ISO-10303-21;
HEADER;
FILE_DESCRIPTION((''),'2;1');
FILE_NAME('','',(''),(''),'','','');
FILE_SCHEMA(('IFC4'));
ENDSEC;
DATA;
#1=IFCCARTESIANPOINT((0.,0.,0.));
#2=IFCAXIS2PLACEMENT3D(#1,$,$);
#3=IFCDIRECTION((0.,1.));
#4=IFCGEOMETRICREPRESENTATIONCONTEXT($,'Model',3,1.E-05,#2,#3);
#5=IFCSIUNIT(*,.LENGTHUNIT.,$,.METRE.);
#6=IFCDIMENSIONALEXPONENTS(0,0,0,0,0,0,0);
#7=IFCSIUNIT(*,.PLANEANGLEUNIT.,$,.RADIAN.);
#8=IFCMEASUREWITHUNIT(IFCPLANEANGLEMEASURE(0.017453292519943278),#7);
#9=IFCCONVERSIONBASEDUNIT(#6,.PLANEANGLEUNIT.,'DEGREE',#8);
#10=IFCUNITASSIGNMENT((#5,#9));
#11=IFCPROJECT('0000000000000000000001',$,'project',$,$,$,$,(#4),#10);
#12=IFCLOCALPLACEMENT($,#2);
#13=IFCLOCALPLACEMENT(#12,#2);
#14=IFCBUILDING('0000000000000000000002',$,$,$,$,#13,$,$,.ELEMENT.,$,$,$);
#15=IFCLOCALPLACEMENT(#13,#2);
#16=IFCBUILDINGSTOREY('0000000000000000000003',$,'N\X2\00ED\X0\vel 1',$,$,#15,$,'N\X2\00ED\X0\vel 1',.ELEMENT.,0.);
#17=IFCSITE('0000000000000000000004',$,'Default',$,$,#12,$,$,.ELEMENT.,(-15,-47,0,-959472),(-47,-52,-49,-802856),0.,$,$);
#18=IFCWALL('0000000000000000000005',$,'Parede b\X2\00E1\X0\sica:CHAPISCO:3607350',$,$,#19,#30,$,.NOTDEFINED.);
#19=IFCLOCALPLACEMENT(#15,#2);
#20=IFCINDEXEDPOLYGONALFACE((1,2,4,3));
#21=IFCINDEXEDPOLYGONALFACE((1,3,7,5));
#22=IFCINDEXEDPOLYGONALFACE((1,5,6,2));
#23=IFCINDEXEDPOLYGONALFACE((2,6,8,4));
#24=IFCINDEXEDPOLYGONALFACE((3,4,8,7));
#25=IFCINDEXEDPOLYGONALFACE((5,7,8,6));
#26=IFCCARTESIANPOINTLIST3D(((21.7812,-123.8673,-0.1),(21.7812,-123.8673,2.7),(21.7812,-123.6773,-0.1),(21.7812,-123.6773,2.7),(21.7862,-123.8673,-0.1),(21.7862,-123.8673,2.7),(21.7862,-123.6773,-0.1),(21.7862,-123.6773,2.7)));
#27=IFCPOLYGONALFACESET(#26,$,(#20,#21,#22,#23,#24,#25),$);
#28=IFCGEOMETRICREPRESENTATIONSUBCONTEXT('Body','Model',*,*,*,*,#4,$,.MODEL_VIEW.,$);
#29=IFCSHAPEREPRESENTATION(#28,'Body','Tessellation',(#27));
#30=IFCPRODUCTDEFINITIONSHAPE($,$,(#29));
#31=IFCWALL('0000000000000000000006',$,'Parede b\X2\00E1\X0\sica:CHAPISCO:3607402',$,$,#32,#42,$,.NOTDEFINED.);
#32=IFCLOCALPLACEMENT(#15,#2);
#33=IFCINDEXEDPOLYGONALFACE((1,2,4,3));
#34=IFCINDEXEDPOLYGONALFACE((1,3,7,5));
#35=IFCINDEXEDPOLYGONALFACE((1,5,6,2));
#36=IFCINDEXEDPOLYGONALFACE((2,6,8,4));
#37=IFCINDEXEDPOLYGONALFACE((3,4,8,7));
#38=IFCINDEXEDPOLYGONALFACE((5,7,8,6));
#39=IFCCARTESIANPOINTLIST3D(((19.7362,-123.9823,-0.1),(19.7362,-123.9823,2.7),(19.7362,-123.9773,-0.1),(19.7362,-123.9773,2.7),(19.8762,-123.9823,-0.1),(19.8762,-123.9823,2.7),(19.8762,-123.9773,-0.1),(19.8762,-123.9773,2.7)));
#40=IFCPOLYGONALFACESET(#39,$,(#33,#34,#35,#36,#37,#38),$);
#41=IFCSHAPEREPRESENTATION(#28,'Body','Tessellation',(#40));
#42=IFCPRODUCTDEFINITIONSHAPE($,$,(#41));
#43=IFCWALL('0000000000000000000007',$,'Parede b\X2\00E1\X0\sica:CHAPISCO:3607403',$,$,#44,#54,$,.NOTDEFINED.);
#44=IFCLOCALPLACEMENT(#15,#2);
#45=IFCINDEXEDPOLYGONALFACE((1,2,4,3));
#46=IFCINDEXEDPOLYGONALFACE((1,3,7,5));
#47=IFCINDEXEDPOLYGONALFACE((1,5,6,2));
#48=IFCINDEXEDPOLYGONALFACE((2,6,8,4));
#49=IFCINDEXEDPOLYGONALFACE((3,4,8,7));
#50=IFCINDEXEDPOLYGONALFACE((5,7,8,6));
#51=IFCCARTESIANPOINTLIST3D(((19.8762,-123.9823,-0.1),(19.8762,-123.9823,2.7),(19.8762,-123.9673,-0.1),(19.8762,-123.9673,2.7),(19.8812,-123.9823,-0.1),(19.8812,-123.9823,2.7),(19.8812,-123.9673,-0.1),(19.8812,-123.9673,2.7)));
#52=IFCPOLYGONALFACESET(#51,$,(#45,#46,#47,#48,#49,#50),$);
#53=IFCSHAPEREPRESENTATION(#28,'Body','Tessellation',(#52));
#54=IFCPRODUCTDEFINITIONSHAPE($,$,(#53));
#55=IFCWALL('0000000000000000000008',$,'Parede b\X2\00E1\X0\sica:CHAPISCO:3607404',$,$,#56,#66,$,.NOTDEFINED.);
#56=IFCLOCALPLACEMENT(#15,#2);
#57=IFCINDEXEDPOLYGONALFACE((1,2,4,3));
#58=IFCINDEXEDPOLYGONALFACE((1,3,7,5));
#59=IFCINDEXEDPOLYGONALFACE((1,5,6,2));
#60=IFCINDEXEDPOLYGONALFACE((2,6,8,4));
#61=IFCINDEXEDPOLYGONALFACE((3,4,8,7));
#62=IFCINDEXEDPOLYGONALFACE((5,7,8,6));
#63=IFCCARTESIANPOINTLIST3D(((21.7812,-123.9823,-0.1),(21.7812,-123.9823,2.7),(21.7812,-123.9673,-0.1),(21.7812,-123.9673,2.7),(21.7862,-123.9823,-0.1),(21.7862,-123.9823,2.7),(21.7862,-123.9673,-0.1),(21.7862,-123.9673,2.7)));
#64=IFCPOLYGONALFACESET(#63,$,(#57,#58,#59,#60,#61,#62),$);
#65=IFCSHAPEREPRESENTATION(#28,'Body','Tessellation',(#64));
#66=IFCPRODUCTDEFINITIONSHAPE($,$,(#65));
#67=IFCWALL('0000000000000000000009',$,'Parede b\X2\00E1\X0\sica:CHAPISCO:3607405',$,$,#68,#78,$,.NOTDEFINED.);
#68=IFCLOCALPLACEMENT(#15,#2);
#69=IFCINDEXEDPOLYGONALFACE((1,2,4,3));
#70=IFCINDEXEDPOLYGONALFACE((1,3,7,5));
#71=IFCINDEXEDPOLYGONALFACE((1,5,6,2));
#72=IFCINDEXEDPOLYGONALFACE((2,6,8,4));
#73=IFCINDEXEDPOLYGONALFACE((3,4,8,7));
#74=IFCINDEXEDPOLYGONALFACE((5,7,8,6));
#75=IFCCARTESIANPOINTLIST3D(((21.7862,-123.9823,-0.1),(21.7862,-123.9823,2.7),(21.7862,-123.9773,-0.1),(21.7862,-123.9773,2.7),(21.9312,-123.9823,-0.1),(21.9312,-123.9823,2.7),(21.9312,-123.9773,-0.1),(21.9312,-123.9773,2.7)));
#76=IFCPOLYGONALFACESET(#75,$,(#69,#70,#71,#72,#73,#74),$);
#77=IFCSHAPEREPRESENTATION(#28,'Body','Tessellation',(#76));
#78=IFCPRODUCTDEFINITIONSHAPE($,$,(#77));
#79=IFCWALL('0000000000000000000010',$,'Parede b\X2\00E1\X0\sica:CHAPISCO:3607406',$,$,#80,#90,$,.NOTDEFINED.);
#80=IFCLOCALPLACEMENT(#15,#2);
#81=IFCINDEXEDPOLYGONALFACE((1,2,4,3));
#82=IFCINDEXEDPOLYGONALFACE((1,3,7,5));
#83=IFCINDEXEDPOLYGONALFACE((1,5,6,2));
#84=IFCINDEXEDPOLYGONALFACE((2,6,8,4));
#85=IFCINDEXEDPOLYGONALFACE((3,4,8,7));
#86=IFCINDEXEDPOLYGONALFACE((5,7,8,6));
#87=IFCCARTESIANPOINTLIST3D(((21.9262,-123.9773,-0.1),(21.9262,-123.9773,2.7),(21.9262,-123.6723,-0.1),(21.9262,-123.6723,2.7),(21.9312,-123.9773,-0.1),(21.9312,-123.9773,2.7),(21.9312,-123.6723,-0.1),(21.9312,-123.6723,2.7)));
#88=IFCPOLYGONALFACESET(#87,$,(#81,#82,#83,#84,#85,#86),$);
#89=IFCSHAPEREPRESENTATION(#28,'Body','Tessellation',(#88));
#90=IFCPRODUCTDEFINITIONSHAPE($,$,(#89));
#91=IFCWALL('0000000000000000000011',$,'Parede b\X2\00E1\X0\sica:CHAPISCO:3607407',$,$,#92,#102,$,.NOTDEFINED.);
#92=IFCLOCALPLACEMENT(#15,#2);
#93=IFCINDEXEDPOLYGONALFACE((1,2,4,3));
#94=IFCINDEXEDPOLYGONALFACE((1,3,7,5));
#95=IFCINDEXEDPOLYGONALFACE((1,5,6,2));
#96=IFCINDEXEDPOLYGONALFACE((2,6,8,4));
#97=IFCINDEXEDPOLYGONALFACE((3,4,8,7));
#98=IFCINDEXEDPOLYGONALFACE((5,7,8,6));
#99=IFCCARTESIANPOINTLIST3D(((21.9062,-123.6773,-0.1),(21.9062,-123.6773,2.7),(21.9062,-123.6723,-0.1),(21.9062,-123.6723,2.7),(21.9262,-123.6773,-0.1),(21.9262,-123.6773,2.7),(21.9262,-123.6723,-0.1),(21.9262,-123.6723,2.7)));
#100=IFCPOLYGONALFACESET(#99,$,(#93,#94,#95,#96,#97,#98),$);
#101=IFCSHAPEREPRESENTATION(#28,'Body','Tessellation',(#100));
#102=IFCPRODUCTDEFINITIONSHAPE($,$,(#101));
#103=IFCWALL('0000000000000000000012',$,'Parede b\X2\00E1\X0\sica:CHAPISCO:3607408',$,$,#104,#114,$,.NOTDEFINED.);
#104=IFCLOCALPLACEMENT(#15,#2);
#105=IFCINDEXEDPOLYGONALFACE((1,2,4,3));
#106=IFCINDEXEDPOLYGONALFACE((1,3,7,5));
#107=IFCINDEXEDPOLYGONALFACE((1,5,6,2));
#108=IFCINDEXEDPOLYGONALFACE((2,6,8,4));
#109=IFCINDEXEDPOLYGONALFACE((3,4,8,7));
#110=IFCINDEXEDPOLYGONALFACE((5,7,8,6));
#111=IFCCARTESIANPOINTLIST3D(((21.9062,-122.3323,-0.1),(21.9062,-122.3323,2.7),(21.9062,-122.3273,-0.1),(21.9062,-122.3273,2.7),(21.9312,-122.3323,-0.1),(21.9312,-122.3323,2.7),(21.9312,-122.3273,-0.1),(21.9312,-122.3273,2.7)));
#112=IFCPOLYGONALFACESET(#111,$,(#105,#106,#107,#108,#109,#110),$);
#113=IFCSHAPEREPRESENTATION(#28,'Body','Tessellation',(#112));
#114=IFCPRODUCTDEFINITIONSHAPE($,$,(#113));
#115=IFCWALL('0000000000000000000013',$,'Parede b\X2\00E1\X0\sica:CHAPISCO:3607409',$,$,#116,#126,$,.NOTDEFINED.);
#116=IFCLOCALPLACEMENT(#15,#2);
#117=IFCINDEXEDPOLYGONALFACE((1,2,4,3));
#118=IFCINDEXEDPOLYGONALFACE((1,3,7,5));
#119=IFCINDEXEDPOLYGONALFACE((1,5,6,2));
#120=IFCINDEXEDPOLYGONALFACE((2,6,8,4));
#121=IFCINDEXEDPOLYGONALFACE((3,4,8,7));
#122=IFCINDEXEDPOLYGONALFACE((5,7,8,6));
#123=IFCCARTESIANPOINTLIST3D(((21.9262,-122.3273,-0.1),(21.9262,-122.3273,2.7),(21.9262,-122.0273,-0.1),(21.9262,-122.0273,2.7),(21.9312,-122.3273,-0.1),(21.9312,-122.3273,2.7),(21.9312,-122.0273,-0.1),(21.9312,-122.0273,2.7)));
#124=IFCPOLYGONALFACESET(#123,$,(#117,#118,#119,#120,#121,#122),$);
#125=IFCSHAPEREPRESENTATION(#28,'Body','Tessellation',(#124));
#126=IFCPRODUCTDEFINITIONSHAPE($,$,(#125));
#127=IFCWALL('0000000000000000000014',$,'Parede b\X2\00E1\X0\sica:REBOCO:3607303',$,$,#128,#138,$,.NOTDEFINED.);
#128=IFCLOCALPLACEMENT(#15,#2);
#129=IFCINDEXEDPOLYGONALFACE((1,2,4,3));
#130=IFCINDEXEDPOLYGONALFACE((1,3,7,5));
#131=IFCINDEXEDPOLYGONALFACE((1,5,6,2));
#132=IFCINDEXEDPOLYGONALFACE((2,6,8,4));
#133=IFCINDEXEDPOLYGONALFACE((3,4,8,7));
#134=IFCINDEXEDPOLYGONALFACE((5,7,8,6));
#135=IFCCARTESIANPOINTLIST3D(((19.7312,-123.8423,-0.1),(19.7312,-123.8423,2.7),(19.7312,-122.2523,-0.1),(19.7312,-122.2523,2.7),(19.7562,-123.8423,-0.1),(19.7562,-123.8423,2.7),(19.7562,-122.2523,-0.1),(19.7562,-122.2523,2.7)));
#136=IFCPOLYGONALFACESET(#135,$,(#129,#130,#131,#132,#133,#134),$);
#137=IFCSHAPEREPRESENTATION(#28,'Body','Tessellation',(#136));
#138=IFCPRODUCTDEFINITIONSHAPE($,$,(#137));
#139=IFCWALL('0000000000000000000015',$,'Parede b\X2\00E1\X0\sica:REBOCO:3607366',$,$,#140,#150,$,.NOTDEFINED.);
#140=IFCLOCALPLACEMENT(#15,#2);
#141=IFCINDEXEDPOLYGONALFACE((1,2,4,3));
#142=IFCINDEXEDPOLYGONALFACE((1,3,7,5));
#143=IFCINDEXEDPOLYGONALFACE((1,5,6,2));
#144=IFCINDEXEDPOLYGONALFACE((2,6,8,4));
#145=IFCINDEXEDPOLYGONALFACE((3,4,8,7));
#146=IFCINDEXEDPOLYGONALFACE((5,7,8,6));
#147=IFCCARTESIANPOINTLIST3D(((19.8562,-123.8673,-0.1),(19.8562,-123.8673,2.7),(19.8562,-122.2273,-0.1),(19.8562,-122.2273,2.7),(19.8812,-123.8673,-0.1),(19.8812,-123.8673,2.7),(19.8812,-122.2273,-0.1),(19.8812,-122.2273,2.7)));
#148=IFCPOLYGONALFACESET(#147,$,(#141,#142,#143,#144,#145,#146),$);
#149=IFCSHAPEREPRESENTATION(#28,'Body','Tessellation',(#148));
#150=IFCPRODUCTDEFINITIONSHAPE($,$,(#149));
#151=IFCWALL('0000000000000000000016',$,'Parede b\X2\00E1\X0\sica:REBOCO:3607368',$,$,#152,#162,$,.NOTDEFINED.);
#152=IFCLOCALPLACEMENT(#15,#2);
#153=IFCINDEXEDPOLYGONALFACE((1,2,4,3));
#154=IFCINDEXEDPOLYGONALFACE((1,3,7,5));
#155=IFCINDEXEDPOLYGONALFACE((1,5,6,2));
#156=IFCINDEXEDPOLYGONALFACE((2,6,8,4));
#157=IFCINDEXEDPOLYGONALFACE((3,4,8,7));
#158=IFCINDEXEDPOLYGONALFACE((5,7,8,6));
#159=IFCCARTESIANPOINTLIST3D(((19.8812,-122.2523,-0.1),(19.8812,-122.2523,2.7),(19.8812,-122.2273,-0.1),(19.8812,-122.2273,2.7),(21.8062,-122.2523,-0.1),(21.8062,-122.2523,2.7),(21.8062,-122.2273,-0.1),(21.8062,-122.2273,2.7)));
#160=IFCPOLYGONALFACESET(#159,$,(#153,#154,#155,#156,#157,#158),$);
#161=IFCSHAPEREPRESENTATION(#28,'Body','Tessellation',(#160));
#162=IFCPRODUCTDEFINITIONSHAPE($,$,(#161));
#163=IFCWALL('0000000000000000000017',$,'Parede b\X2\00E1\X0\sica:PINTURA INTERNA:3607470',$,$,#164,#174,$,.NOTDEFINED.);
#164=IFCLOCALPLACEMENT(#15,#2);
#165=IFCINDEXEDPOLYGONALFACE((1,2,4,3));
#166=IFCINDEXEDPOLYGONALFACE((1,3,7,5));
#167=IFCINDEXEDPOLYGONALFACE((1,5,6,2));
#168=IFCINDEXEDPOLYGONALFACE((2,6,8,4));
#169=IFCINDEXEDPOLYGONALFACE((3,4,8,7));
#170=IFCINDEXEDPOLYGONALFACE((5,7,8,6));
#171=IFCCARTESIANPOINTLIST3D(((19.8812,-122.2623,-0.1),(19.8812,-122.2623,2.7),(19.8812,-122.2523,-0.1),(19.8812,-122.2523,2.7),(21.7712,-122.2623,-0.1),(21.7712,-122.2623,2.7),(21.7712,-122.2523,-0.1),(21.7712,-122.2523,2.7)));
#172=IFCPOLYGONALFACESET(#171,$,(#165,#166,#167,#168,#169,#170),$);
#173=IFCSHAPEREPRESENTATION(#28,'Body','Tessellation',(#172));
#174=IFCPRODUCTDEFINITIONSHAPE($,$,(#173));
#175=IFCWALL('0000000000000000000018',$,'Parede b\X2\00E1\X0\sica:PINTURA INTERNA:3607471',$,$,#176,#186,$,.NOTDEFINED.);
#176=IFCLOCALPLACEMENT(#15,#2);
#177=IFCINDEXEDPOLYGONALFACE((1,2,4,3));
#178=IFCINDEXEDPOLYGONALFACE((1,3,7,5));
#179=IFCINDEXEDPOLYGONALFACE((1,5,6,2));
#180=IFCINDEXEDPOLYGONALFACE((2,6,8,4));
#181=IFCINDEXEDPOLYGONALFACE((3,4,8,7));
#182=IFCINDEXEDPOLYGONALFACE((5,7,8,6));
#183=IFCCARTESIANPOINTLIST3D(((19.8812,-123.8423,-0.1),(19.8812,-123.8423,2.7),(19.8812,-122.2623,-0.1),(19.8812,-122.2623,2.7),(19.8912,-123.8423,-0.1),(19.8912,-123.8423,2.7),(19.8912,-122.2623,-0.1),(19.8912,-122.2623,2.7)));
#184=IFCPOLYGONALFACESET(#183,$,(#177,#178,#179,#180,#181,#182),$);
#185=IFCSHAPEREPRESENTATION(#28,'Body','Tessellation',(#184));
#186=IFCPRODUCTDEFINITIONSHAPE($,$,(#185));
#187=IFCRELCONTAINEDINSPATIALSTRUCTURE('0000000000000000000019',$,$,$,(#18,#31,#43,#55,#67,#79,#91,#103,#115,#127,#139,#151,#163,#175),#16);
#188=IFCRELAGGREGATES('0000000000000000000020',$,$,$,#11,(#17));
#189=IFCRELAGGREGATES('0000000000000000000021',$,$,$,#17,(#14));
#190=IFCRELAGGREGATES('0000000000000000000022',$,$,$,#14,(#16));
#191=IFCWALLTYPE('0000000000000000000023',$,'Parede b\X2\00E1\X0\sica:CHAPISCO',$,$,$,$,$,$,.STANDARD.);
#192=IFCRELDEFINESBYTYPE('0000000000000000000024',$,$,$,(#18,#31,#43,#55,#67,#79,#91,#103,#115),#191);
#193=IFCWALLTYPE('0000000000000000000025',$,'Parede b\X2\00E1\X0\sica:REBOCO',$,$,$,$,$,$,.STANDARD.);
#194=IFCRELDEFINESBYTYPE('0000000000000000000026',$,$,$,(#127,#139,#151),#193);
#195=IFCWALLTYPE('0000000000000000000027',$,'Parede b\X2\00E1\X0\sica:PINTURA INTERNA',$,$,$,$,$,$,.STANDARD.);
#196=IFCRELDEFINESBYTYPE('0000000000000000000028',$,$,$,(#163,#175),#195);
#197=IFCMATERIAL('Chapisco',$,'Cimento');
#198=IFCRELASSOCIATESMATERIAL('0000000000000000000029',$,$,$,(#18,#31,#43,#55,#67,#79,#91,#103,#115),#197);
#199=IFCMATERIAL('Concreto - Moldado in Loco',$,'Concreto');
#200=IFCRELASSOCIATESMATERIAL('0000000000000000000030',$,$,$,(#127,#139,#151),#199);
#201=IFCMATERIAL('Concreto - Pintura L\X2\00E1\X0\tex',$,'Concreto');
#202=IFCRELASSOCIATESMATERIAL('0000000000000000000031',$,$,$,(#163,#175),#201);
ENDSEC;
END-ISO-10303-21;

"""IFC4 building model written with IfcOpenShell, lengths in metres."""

from ifc_helpers import new_model, entity, si_unit, converted_unit, direction, frame, origin, place, context, subcontext, project, spatial, indexed_curve, outline, extrude, material, type_object, element, save


model = new_model("IFC4")

# Units and contexts
model_context = context("Model", 3, precision=1e-05, world=origin(), true_north=direction((0.0, 1.0)))
body_context = subcontext(model_context, "Body", "Model", "MODEL_VIEW")
ifc_project = project(units=[si_unit("LENGTHUNIT", "METRE"), converted_unit("PLANEANGLEUNIT", "DEGREE", entity("IfcPlaneAngleMeasure", 0.017453292519943278), si_unit("PLANEANGLEUNIT", "RADIAN"), dimensions=[0, 0, 0, 0, 0, 0, 0])], contexts=[model_context])

# Site, building, storey
site_placement = place(None, origin())
site = spatial("IfcSite", under=ifc_project, at=site_placement, Name="Default", CompositionType="ELEMENT", RefLatitude=(-15, -47, 0, -959472), RefLongitude=(-47, -52, -49, -802856), RefElevation=0.0)
building_placement = place(site_placement, origin())
building = spatial("IfcBuilding", under=site, at=building_placement, CompositionType="ELEMENT")
storey_placement = place(building_placement, origin())
storey = spatial("IfcBuildingStorey", under=building, at=storey_placement, Name="Nível 1", LongName="Nível 1", CompositionType="ELEMENT", Elevation=0.0)

# Walls
ifc_material_1 = material(Name="Chapisco", Category="Cimento")
wall_type_1 = type_object("IfcWallType", Name="Parede básica:CHAPISCO", PredefinedType="STANDARD")
wall_1_placement = place(storey_placement, frame((21.7837, -123.6773, -0.1), z_axis=(0.0, 0.0, 1.0), x_axis=(0.0, -1.0, 0.0)))
element("IfcWall", 1, at=wall_1_placement, inside=storey, type_object=wall_type_1, material=ifc_material_1, Name="Parede básica:CHAPISCO:3607350", PredefinedType="NOTDEFINED", context=body_context, shape_type="SweptSolid", body=[
    extrude(outline(indexed_curve([(0.19, 0.0025), (0.0, 0.0025), (0.0, -0.0025), (0.19, -0.0025), (0.19, 0.0025)], self_intersect=False)), origin(), (0.0, 0.0, 1.0), 2.8),
])
wall_2_placement = place(storey_placement, frame((19.7362, -123.9798, -0.1)))
element("IfcWall", 2, at=wall_2_placement, inside=storey, type_object=wall_type_1, material=ifc_material_1, Name="Parede básica:CHAPISCO:3607402", PredefinedType="NOTDEFINED", context=body_context, shape_type="SweptSolid", body=[
    extrude(outline(indexed_curve([(0.14, 0.0025), (0.0, 0.0025), (0.0, -0.0025), (0.14, -0.0025), (0.14, 0.0025)], self_intersect=False)), origin(), (0.0, 0.0, 1.0), 2.8),
])
for number, where, z_axis, x_axis, name in (
    (3, (19.8787, -123.9823, -0.1), (0.0, 0.0, 1.0), (0.0, 1.0, 0.0), "Parede básica:CHAPISCO:3607403"),
    (4, (21.7837, -123.9673, -0.1), (0.0, 0.0, 1.0), (0.0, -1.0, 0.0), "Parede básica:CHAPISCO:3607404"),
):
    element("IfcWall", number, at=place(storey_placement, frame(where, z_axis=z_axis, x_axis=x_axis)), inside=storey, type_object=wall_type_1, material=ifc_material_1, Name=name, PredefinedType="NOTDEFINED", context=body_context, shape_type="SweptSolid", body=[
        extrude(outline(indexed_curve([(0.015, 0.0025), (0.0, 0.0025), (0.0, -0.0025), (0.015, -0.0025), (0.015, 0.0025)], self_intersect=False)), origin(), (0.0, 0.0, 1.0), 2.8),
    ])
wall_3_placement = place(storey_placement, frame((21.7862, -123.9798, -0.1)))
element("IfcWall", 5, at=wall_3_placement, inside=storey, type_object=wall_type_1, material=ifc_material_1, Name="Parede básica:CHAPISCO:3607405", PredefinedType="NOTDEFINED", context=body_context, shape_type="SweptSolid", body=[
    extrude(outline(indexed_curve([(0.145, 0.0025), (0.0, 0.0025), (0.0, -0.0025), (0.145, -0.0025), (0.145, 0.0025)], self_intersect=False)), origin(), (0.0, 0.0, 1.0), 2.8),
])
wall_4_placement = place(storey_placement, frame((21.9287, -123.9773, -0.1), z_axis=(0.0, 0.0, 1.0), x_axis=(0.0, 1.0, 0.0)))
element("IfcWall", 6, at=wall_4_placement, inside=storey, type_object=wall_type_1, material=ifc_material_1, Name="Parede básica:CHAPISCO:3607406", PredefinedType="NOTDEFINED", context=body_context, shape_type="SweptSolid", body=[
    extrude(outline(indexed_curve([(0.305, 0.0025), (0.0, 0.0025), (0.0, -0.0025), (0.305, -0.0025), (0.305, 0.0025)], self_intersect=False)), origin(), (0.0, 0.0, 1.0), 2.8),
])
wall_5_placement = place(storey_placement, frame((21.9262, -123.6748, -0.1), z_axis=(0.0, 0.0, 1.0), x_axis=(-1.0, 0.0, 0.0)))
element("IfcWall", 7, at=wall_5_placement, inside=storey, type_object=wall_type_1, material=ifc_material_1, Name="Parede básica:CHAPISCO:3607407", PredefinedType="NOTDEFINED", context=body_context, shape_type="SweptSolid", body=[
    extrude(outline(indexed_curve([(0.02, 0.0025), (0.0, 0.0025), (0.0, -0.0025), (0.02, -0.0025), (0.02, 0.0025)], self_intersect=False)), origin(), (0.0, 0.0, 1.0), 2.8),
])
wall_6_placement = place(storey_placement, frame((21.9062, -122.3298, -0.1)))
element("IfcWall", 8, at=wall_6_placement, inside=storey, type_object=wall_type_1, material=ifc_material_1, Name="Parede básica:CHAPISCO:3607408", PredefinedType="NOTDEFINED", context=body_context, shape_type="SweptSolid", body=[
    extrude(outline(indexed_curve([(0.025, 0.0025), (0.0, 0.0025), (0.0, -0.0025), (0.025, -0.0025), (0.025, 0.0025)], self_intersect=False)), origin(), (0.0, 0.0, 1.0), 2.8),
])
wall_7_placement = place(storey_placement, frame((21.9287, -122.3273, -0.1), z_axis=(0.0, 0.0, 1.0), x_axis=(0.0, 1.0, 0.0)))
element("IfcWall", 9, at=wall_7_placement, inside=storey, type_object=wall_type_1, material=ifc_material_1, Name="Parede básica:CHAPISCO:3607409", PredefinedType="NOTDEFINED", context=body_context, shape_type="SweptSolid", body=[
    extrude(outline(indexed_curve([(0.3, 0.0025), (0.0, 0.0025), (0.0, -0.0025), (0.3, -0.0025), (0.3, 0.0025)], self_intersect=False)), origin(), (0.0, 0.0, 1.0), 2.8),
])
ifc_material_2 = material(Name="Concreto - Moldado in Loco", Category="Concreto")
wall_type_2 = type_object("IfcWallType", Name="Parede básica:REBOCO", PredefinedType="STANDARD")
wall_8_placement = place(storey_placement, frame((19.7437, -122.2523, -0.1), z_axis=(0.0, 0.0, 1.0), x_axis=(0.0, -1.0, 0.0)))
element("IfcWall", 10, at=wall_8_placement, inside=storey, type_object=wall_type_2, material=ifc_material_2, Name="Parede básica:REBOCO:3607303", PredefinedType="NOTDEFINED", context=body_context, shape_type="SweptSolid", body=[
    extrude(outline(indexed_curve([(1.59, 0.0125), (0.0, 0.0125), (0.0, -0.0125), (1.59, -0.0125), (1.59, 0.0125)], self_intersect=False)), origin(), (0.0, 0.0, 1.0), 2.8),
])
wall_9_placement = place(storey_placement, frame((19.8687, -123.8673, -0.1), z_axis=(0.0, 0.0, 1.0), x_axis=(0.0, 1.0, 0.0)))
element("IfcWall", 11, at=wall_9_placement, inside=storey, type_object=wall_type_2, material=ifc_material_2, Name="Parede básica:REBOCO:3607366", PredefinedType="NOTDEFINED", context=body_context, shape_type="SweptSolid", body=[
    extrude(outline(indexed_curve([(1.64, 0.0125), (0.0, 0.0125), (0.0, -0.0125), (1.64, -0.0125), (1.64, 0.0125)], self_intersect=False)), origin(), (0.0, 0.0, 1.0), 2.8),
])
wall_10_placement = place(storey_placement, frame((19.8812, -122.2398, -0.1)))
element("IfcWall", 12, at=wall_10_placement, inside=storey, type_object=wall_type_2, material=ifc_material_2, Name="Parede básica:REBOCO:3607368", PredefinedType="NOTDEFINED", context=body_context, shape_type="SweptSolid", body=[
    extrude(outline(indexed_curve([(1.925, 0.0125), (0.0, 0.0125), (0.0, -0.0125), (1.925, -0.0125), (1.925, 0.0125)], self_intersect=False)), origin(), (0.0, 0.0, 1.0), 2.8),
])
ifc_material_3 = material(Name="Concreto - Pintura Látex", Category="Concreto")
wall_type_3 = type_object("IfcWallType", Name="Parede básica:PINTURA INTERNA", PredefinedType="STANDARD")
wall_11_placement = place(storey_placement, frame((19.8812, -122.2573, -0.1)))
element("IfcWall", 13, at=wall_11_placement, inside=storey, type_object=wall_type_3, material=ifc_material_3, Name="Parede básica:PINTURA INTERNA:3607470", PredefinedType="NOTDEFINED", context=body_context, shape_type="SweptSolid", body=[
    extrude(outline(indexed_curve([(1.89, 0.005), (0.0, 0.005), (0.0, -0.005), (1.89, -0.005), (1.89, 0.005)], self_intersect=False)), origin(), (0.0, 0.0, 1.0), 2.8),
])
wall_12_placement = place(storey_placement, frame((19.8862, -123.8423, -0.1), z_axis=(0.0, 0.0, 1.0), x_axis=(0.0, 1.0, 0.0)))
element("IfcWall", 14, at=wall_12_placement, inside=storey, type_object=wall_type_3, material=ifc_material_3, Name="Parede básica:PINTURA INTERNA:3607471", PredefinedType="NOTDEFINED", context=body_context, shape_type="SweptSolid", body=[
    extrude(outline(indexed_curve([(1.58, 0.005), (0.0, 0.005), (0.0, -0.005), (1.58, -0.005), (1.58, 0.005)], self_intersect=False)), origin(), (0.0, 0.0, 1.0), 2.8),
])

save(model, "model.ifc")
